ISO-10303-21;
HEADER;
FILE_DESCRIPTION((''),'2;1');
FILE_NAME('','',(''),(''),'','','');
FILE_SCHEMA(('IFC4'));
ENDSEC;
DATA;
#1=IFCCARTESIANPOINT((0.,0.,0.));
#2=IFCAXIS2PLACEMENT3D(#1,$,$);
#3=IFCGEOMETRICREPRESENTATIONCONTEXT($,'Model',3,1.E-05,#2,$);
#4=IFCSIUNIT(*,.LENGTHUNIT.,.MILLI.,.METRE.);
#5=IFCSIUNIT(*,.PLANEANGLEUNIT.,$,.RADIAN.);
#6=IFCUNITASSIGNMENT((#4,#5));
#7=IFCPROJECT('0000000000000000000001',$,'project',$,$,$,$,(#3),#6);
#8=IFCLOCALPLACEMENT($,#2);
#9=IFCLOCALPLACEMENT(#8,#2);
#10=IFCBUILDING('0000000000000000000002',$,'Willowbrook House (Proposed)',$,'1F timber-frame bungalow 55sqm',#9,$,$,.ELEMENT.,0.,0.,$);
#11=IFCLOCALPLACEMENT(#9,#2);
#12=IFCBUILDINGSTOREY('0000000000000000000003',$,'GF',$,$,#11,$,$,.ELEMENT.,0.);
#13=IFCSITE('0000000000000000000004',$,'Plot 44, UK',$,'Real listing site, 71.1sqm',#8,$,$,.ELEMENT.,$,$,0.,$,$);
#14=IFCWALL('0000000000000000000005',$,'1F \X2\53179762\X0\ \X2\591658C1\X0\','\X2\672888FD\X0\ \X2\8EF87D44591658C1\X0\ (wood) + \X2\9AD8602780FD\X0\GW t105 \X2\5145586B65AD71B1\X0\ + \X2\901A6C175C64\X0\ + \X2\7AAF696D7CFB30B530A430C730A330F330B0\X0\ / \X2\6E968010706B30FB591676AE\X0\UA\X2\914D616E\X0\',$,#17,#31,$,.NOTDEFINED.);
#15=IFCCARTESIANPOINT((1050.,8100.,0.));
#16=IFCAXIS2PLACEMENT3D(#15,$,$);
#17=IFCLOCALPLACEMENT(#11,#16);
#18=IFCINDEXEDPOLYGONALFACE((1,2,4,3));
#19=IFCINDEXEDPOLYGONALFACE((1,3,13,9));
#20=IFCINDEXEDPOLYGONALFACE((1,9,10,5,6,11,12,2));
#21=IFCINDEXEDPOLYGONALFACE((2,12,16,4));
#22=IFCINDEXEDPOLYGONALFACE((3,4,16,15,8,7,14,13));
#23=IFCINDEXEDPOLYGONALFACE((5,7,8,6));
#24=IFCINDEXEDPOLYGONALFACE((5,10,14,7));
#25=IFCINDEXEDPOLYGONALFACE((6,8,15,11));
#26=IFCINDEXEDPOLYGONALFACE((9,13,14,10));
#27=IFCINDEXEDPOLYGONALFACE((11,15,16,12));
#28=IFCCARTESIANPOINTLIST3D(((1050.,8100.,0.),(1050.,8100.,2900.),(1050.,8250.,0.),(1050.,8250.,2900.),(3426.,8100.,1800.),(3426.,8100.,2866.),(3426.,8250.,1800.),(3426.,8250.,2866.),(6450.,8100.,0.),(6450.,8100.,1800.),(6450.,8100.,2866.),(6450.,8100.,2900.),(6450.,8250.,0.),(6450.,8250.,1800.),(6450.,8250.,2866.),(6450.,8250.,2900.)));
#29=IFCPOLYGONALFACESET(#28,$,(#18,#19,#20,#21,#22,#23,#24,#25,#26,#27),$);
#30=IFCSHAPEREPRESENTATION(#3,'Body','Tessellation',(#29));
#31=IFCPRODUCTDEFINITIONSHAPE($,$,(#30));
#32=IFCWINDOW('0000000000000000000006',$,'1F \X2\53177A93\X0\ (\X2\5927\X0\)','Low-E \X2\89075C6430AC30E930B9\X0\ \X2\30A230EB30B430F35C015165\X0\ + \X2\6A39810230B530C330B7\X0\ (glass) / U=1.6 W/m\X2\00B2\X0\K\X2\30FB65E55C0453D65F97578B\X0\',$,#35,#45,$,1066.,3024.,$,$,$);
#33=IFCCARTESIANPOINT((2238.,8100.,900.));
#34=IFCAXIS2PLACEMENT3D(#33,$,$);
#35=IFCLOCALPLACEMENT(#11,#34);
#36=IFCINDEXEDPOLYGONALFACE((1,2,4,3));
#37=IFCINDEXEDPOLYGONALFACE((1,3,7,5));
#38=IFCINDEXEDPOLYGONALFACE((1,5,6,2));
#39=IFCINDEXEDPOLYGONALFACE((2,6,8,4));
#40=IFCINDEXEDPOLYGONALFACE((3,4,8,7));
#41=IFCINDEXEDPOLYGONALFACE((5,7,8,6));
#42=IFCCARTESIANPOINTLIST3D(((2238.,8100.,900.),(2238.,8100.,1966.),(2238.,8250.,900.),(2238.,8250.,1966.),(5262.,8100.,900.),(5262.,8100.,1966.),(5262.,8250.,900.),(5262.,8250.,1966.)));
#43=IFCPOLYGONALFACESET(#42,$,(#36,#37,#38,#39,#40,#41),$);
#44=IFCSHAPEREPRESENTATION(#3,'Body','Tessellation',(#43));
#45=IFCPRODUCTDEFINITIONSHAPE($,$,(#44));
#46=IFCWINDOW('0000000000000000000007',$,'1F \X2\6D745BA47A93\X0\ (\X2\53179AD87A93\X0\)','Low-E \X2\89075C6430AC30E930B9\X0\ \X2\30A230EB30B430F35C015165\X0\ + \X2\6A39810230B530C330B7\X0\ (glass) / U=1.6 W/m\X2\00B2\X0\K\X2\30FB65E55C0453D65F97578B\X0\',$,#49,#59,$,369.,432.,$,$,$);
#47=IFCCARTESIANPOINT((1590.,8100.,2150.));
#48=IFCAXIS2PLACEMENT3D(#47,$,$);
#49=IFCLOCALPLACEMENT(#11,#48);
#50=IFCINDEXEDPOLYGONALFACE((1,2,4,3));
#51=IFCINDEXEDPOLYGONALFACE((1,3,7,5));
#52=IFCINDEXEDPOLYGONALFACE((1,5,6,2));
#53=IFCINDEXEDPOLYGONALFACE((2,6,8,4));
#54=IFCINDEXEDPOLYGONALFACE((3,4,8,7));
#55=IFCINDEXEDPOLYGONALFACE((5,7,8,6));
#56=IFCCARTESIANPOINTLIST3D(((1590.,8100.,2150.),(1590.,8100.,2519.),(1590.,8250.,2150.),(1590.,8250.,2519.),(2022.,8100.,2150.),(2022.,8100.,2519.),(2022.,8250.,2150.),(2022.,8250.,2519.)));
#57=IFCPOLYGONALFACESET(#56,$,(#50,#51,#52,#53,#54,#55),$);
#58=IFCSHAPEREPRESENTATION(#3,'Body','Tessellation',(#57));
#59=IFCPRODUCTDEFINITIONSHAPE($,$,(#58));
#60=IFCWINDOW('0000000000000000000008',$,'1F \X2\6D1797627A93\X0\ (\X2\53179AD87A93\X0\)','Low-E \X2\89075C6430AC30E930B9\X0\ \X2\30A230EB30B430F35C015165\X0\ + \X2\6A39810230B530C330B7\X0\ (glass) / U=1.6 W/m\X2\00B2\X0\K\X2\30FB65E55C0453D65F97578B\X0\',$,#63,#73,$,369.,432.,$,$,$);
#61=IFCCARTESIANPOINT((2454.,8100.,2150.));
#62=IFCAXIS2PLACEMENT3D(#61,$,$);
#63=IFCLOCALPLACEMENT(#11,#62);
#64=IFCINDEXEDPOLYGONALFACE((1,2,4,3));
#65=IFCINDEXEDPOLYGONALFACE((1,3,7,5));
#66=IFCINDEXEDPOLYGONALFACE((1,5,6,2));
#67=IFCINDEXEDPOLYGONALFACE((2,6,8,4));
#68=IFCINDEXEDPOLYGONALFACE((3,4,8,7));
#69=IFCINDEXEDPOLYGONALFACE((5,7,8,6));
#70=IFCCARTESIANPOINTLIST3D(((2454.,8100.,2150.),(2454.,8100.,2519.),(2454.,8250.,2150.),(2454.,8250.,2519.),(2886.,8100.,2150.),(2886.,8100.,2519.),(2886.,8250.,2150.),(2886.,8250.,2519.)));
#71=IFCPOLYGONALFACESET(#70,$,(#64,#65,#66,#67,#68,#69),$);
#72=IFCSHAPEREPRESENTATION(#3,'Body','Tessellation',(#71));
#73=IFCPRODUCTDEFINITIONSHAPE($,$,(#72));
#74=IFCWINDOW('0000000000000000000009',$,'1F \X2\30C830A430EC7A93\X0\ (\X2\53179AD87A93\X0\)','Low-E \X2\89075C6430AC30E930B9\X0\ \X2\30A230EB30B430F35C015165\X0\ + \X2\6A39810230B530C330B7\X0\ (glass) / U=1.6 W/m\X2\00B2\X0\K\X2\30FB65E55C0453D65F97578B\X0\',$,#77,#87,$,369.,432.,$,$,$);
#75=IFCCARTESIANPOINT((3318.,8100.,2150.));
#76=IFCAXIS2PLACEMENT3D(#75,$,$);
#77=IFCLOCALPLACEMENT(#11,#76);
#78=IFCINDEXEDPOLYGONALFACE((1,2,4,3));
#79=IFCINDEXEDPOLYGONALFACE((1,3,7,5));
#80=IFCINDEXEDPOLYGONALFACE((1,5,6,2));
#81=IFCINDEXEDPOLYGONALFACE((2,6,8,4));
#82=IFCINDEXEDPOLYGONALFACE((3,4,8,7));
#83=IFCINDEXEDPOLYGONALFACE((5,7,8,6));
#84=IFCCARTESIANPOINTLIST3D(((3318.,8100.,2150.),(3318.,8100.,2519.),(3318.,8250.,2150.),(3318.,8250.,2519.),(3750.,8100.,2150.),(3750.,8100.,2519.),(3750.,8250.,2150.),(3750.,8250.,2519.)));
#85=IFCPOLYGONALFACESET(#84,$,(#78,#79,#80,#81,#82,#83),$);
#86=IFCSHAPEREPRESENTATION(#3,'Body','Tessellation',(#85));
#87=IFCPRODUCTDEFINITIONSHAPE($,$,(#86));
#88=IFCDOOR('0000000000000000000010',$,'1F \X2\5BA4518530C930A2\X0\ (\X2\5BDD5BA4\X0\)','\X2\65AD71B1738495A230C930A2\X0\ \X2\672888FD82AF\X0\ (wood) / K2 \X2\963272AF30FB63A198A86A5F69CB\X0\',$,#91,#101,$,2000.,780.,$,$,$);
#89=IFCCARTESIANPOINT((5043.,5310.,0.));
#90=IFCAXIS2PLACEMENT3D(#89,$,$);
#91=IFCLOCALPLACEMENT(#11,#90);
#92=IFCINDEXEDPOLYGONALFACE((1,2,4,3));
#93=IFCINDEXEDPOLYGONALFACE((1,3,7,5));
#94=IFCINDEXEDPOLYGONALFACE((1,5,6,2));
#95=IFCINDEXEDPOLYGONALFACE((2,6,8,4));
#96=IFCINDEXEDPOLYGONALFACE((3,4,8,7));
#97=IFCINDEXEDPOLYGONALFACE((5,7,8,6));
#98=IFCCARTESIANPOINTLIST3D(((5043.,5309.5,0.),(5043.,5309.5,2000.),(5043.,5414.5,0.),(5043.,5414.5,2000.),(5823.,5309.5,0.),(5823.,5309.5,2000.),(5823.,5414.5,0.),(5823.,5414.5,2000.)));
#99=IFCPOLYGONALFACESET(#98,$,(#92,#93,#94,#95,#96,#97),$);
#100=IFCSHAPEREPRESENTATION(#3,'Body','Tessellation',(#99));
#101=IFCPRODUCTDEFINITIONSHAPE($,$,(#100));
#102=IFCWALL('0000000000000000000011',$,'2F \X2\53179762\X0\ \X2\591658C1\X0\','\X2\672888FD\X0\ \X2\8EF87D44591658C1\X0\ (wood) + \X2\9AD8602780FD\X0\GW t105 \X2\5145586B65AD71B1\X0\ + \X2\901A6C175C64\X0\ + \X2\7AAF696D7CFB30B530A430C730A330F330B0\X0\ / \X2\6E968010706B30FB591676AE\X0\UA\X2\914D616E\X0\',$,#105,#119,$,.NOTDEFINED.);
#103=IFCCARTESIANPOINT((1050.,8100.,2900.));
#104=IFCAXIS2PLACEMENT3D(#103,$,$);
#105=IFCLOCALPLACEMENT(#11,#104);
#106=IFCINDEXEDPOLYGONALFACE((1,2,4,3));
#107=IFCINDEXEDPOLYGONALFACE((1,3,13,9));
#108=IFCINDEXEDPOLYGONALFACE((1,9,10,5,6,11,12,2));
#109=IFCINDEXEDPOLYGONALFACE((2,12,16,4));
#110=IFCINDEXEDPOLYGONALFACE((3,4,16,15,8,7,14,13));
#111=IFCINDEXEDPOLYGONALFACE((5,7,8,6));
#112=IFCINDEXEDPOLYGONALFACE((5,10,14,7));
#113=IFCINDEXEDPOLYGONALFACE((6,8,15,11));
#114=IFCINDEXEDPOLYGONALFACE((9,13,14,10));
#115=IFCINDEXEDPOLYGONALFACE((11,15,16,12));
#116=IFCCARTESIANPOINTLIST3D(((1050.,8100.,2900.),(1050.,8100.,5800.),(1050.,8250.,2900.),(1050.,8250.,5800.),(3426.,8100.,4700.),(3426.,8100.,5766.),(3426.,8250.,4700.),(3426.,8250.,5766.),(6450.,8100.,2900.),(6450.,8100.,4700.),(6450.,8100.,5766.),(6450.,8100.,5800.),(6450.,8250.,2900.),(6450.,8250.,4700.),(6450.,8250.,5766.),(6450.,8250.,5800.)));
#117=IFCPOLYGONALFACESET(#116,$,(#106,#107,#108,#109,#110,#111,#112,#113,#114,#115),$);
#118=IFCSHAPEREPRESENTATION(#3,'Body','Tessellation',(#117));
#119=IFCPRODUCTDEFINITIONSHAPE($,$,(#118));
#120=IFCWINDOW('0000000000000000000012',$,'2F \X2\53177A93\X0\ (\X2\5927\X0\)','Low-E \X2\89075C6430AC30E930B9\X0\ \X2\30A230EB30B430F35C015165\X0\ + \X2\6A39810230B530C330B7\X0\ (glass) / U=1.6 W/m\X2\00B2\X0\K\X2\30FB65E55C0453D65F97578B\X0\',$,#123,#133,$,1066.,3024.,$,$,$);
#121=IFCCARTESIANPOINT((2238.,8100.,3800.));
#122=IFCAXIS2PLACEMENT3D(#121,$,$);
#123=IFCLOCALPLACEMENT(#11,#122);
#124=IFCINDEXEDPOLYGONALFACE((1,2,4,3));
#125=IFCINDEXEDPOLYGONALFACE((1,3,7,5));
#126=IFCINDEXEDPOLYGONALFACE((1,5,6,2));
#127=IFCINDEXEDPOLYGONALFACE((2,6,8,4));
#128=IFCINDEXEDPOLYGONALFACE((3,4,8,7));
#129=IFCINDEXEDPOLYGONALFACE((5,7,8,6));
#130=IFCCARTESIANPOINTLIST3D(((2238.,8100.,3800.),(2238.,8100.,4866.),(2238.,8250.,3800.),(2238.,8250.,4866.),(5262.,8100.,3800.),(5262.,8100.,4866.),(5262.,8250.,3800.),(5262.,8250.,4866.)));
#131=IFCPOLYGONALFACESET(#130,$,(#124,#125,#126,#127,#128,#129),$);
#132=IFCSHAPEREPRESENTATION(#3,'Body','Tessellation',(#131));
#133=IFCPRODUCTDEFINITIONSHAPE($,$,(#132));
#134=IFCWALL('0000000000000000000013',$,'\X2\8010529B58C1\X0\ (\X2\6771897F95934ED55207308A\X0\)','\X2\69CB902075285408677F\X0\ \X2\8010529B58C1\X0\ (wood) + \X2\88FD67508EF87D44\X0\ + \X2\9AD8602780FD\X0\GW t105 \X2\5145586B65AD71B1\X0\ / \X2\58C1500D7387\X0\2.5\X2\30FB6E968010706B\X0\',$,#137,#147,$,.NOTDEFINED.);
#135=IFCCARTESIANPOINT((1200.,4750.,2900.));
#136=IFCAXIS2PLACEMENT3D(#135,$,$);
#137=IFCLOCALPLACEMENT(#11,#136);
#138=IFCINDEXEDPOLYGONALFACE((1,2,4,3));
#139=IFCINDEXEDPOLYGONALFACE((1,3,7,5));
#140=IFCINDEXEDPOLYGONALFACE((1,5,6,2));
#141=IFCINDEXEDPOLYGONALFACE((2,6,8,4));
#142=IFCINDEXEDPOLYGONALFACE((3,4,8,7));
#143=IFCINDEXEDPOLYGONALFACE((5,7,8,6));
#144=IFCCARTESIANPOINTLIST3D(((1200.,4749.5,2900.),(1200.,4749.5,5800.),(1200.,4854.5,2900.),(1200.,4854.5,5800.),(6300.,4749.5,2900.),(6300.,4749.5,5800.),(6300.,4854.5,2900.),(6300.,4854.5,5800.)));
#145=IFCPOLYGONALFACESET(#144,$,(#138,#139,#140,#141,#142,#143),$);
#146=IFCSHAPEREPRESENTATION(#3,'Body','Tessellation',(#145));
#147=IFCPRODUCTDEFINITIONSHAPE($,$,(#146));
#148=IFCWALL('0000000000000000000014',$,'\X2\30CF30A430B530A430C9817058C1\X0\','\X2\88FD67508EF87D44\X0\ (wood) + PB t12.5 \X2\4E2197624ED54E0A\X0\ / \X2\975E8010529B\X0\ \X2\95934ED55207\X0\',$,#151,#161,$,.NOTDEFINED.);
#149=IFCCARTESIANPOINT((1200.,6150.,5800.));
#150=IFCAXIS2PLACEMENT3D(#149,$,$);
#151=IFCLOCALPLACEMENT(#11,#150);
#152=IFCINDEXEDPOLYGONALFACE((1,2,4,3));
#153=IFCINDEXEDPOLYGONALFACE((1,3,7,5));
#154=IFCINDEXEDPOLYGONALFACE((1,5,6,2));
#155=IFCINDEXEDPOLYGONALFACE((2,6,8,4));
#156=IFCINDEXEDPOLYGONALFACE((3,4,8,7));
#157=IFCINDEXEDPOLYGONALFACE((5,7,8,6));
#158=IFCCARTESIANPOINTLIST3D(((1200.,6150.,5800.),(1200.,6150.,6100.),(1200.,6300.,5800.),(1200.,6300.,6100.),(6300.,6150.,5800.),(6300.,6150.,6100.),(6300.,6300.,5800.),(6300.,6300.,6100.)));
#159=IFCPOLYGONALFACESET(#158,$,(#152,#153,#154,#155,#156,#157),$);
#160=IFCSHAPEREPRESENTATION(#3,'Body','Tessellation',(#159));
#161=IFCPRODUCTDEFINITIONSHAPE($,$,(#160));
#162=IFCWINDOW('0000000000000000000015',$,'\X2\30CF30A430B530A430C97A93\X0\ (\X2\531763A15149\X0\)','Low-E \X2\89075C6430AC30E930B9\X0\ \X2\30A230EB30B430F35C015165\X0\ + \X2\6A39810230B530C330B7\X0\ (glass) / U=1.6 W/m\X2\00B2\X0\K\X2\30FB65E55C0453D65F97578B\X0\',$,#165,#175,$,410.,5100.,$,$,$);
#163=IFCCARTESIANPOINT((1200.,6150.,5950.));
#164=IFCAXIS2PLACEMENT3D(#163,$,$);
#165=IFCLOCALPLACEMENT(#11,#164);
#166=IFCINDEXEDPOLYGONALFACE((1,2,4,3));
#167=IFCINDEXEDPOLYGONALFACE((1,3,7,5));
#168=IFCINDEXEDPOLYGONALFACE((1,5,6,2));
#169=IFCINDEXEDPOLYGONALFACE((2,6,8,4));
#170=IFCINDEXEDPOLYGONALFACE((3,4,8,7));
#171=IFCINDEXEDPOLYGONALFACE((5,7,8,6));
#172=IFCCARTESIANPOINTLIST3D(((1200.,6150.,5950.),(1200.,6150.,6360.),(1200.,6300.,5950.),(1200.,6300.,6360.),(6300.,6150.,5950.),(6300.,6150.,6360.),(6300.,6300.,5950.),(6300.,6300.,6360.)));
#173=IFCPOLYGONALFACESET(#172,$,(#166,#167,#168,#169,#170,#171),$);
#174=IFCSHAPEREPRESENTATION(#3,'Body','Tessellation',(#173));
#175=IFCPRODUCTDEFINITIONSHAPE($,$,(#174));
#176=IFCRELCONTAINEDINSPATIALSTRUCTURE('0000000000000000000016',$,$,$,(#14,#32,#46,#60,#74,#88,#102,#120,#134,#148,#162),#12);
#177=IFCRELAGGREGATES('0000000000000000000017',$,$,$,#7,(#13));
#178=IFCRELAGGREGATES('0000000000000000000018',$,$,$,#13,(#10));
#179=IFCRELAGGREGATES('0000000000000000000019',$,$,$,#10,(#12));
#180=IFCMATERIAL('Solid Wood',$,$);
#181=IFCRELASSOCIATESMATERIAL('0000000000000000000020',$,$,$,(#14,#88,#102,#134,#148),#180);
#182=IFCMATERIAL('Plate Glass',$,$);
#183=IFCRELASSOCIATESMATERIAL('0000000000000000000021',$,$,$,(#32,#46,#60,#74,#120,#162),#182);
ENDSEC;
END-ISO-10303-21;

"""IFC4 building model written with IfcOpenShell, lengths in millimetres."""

from ifc_helpers import new_model, si_unit, frame, frame_2d, origin, place, context, project, spatial, rectangle, extrude, material, element, fill, save


model = new_model("IFC4")

# Units and contexts
model_context = context("Model", 3, precision=1e-05, world=origin())
ifc_project = project(units=[si_unit("LENGTHUNIT", "METRE", prefix="MILLI"), si_unit("PLANEANGLEUNIT", "RADIAN")], contexts=[model_context])

# Site, building, storey
site_placement = place(None, origin())
site = spatial("IfcSite", under=ifc_project, at=site_placement, Name="Plot 44, UK", ObjectType="Real listing site, 71.1sqm", CompositionType="ELEMENT", RefElevation=0.0)
building_placement = place(site_placement, origin())
building = spatial("IfcBuilding", under=site, at=building_placement, Name="Willowbrook House (Proposed)", ObjectType="1F timber-frame bungalow 55sqm", CompositionType="ELEMENT", ElevationOfRefHeight=0.0, ElevationOfTerrain=0.0)
storey_placement = place(building_placement, origin())
storey = spatial("IfcBuildingStorey", under=building, at=storey_placement, Name="GF", CompositionType="ELEMENT", Elevation=0.0)

# Wall, openings, windows
ifc_material_1 = material(Name="Solid Wood")
wall_1_placement = place(storey_placement, frame((1050.0, 8100.0, 0.0)))
wall_1 = element("IfcWall", 1, at=wall_1_placement, inside=storey, material=ifc_material_1, Name="1F 北面 外壁", Description="木製 軸組外壁 (wood) + 高性能GW t105 充填断熱 + 通気層 + 窯業系サイディング / 準耐火・外皮UA配慮", PredefinedType="NOTDEFINED", context=model_context, shape_type="SweptSolid", body=[
    extrude(rectangle(XDim=5400.0, YDim=150.0, at=frame_2d((2700.0, 75.0))), frame((1050.0, 8100.0, 0.0)), (0.0, 0.0, 1.0), 2900.0),
])
opening_1_placement = place(storey_placement, frame((2238.0, 8100.0, 900.0)))
opening_1 = element("IfcOpeningElement", 2, at=opening_1_placement, cuts=wall_1, PredefinedType="NOTDEFINED", context=model_context, shape_type="SweptSolid", body=[
    extrude(rectangle(XDim=3024.0, YDim=150.0, at=frame_2d((1512.0, 75.0))), frame((2238.0, 8100.0, 900.0)), (0.0, 0.0, 1.0), 1066.0),
])
opening_2_placement = place(storey_placement, frame((1590.0, 8100.0, 2150.0)))
opening_2 = element("IfcOpeningElement", 3, at=opening_2_placement, cuts=wall_1, PredefinedType="NOTDEFINED", context=model_context, shape_type="SweptSolid", body=[
    extrude(rectangle(XDim=432.0, YDim=150.0, at=frame_2d((216.0, 75.0))), frame((1590.0, 8100.0, 2150.0)), (0.0, 0.0, 1.0), 369.0),
])
opening_3_placement = place(storey_placement, frame((2454.0, 8100.0, 2150.0)))
opening_3 = element("IfcOpeningElement", 4, at=opening_3_placement, cuts=wall_1, PredefinedType="NOTDEFINED", context=model_context, shape_type="SweptSolid", body=[
    extrude(rectangle(XDim=432.0, YDim=150.0, at=frame_2d((216.0, 75.0))), frame((2454.0, 8100.0, 2150.0)), (0.0, 0.0, 1.0), 369.0),
])
opening_4_placement = place(storey_placement, frame((3318.0, 8100.0, 2150.0)))
opening_4 = element("IfcOpeningElement", 5, at=opening_4_placement, cuts=wall_1, PredefinedType="NOTDEFINED", context=model_context, shape_type="SweptSolid", body=[
    extrude(rectangle(XDim=432.0, YDim=150.0, at=frame_2d((216.0, 75.0))), frame((3318.0, 8100.0, 2150.0)), (0.0, 0.0, 1.0), 369.0),
])
ifc_material_2 = material(Name="Plate Glass")
window_1_placement = place(storey_placement, frame((2238.0, 8100.0, 900.0)))
window_1 = element("IfcWindow", 6, at=window_1_placement, inside=storey, material=ifc_material_2, Name="1F 北窓 (大)", Description="Low-E 複層ガラス アルゴン封入 + 樹脂サッシ (glass) / U=1.6 W/m²K・日射取得型", OverallHeight=1066.0, OverallWidth=3024.0, context=model_context, shape_type="SweptSolid", body=[
    extrude(rectangle(XDim=3024.0, YDim=150.0, at=frame_2d((1512.0, 75.0))), frame((2238.0, 8100.0, 900.0)), (0.0, 0.0, 1.0), 1066.0),
])
fill(opening_1, window_1)
window_2_placement = place(storey_placement, frame((1590.0, 8100.0, 2150.0)))
window_2 = element("IfcWindow", 7, at=window_2_placement, inside=storey, material=ifc_material_2, Name="1F 浴室窓 (北高窓)", Description="Low-E 複層ガラス アルゴン封入 + 樹脂サッシ (glass) / U=1.6 W/m²K・日射取得型", OverallHeight=369.0, OverallWidth=432.0, context=model_context, shape_type="SweptSolid", body=[
    extrude(rectangle(XDim=432.0, YDim=150.0, at=frame_2d((216.0, 75.0))), frame((1590.0, 8100.0, 2150.0)), (0.0, 0.0, 1.0), 369.0),
])
fill(opening_2, window_2)
window_3_placement = place(storey_placement, frame((2454.0, 8100.0, 2150.0)))
window_3 = element("IfcWindow", 8, at=window_3_placement, inside=storey, material=ifc_material_2, Name="1F 洗面窓 (北高窓)", Description="Low-E 複層ガラス アルゴン封入 + 樹脂サッシ (glass) / U=1.6 W/m²K・日射取得型", OverallHeight=369.0, OverallWidth=432.0, context=model_context, shape_type="SweptSolid", body=[
    extrude(rectangle(XDim=432.0, YDim=150.0, at=frame_2d((216.0, 75.0))), frame((2454.0, 8100.0, 2150.0)), (0.0, 0.0, 1.0), 369.0),
])
fill(opening_3, window_3)
window_4_placement = place(storey_placement, frame((3318.0, 8100.0, 2150.0)))
window_4 = element("IfcWindow", 9, at=window_4_placement, inside=storey, material=ifc_material_2, Name="1F トイレ窓 (北高窓)", Description="Low-E 複層ガラス アルゴン封入 + 樹脂サッシ (glass) / U=1.6 W/m²K・日射取得型", OverallHeight=369.0, OverallWidth=432.0, context=model_context, shape_type="SweptSolid", body=[
    extrude(rectangle(XDim=432.0, YDim=150.0, at=frame_2d((216.0, 75.0))), frame((3318.0, 8100.0, 2150.0)), (0.0, 0.0, 1.0), 369.0),
])
fill(opening_4, window_4)

# Door
door_1_placement = place(storey_placement, frame((5043.0, 5310.0, 0.0)))
element("IfcDoor", 10, at=door_1_placement, inside=storey, material=ifc_material_1, Name="1F 室内ドア (寝室)", Description="断熱玄関ドア 木製芯 (wood) / K2 防犯・採風機構", OverallHeight=2000.0, OverallWidth=780.0, context=model_context, shape_type="SweptSolid", body=[
    extrude(rectangle(XDim=780.0, YDim=105.0, at=frame_2d((390.0, 52.0))), frame((5043.0, 5310.0, 0.0)), (0.0, 0.0, 1.0), 2000.0),
])

# Wall, opening, window
wall_2_placement = place(storey_placement, frame((1050.0, 8100.0, 2900.0)))
wall_2 = element("IfcWall", 11, at=wall_2_placement, inside=storey, material=ifc_material_1, Name="2F 北面 外壁", Description="木製 軸組外壁 (wood) + 高性能GW t105 充填断熱 + 通気層 + 窯業系サイディング / 準耐火・外皮UA配慮", PredefinedType="NOTDEFINED", context=model_context, shape_type="SweptSolid", body=[
    extrude(rectangle(XDim=5400.0, YDim=150.0, at=frame_2d((2700.0, 75.0))), frame((1050.0, 8100.0, 2900.0)), (0.0, 0.0, 1.0), 2900.0),
])
opening_5_placement = place(storey_placement, frame((2238.0, 8100.0, 3800.0)))
opening_5 = element("IfcOpeningElement", 12, at=opening_5_placement, cuts=wall_2, PredefinedType="NOTDEFINED", context=model_context, shape_type="SweptSolid", body=[
    extrude(rectangle(XDim=3024.0, YDim=150.0, at=frame_2d((1512.0, 75.0))), frame((2238.0, 8100.0, 3800.0)), (0.0, 0.0, 1.0), 1066.0),
])
window_5_placement = place(storey_placement, frame((2238.0, 8100.0, 3800.0)))
window_5 = element("IfcWindow", 13, at=window_5_placement, inside=storey, material=ifc_material_2, Name="2F 北窓 (大)", Description="Low-E 複層ガラス アルゴン封入 + 樹脂サッシ (glass) / U=1.6 W/m²K・日射取得型", OverallHeight=1066.0, OverallWidth=3024.0, context=model_context, shape_type="SweptSolid", body=[
    extrude(rectangle(XDim=3024.0, YDim=150.0, at=frame_2d((1512.0, 75.0))), frame((2238.0, 8100.0, 3800.0)), (0.0, 0.0, 1.0), 1066.0),
])
fill(opening_5, window_5)

# Wall
wall_3_placement = place(storey_placement, frame((1200.0, 4750.0, 2900.0)))
element("IfcWall", 14, at=wall_3_placement, inside=storey, material=ifc_material_1, Name="耐力壁 (東西間仕切り)", Description="構造用合板 耐力壁 (wood) + 製材軸組 + 高性能GW t105 充填断熱 / 壁倍率2.5・準耐火", PredefinedType="NOTDEFINED", context=model_context, shape_type="SweptSolid", body=[
    extrude(rectangle(XDim=5100.0, YDim=105.0, at=frame_2d((2550.0, 52.0))), frame((1200.0, 4750.0, 2900.0)), (0.0, 0.0, 1.0), 2900.0),
])

# Wall, opening, window
wall_4_placement = place(storey_placement, frame((1200.0, 6150.0, 5800.0)))
wall_4 = element("IfcWall", 15, at=wall_4_placement, inside=storey, material=ifc_material_1, Name="ハイサイド腰壁", Description="製材軸組 (wood) + PB t12.5 両面仕上 / 非耐力 間仕切", PredefinedType="NOTDEFINED", context=model_context, shape_type="SweptSolid", body=[
    extrude(rectangle(XDim=5100.0, YDim=150.0, at=frame_2d((2550.0, 75.0))), frame((1200.0, 6150.0, 5800.0)), (0.0, 0.0, 1.0), 700.0),
])
opening_6_placement = place(storey_placement, frame((1200.0, 6150.0, 5950.0)))
opening_6 = element("IfcOpeningElement", 16, at=opening_6_placement, cuts=wall_4, PredefinedType="NOTDEFINED", context=model_context, shape_type="SweptSolid", body=[
    extrude(rectangle(XDim=5100.0, YDim=150.0, at=frame_2d((2550.0, 75.0))), frame((1200.0, 6150.0, 5950.0)), (0.0, 0.0, 1.0), 410.0),
])
window_6_placement = place(storey_placement, frame((1200.0, 6150.0, 5950.0)))
window_6 = element("IfcWindow", 17, at=window_6_placement, inside=storey, material=ifc_material_2, Name="ハイサイド窓 (北採光)", Description="Low-E 複層ガラス アルゴン封入 + 樹脂サッシ (glass) / U=1.6 W/m²K・日射取得型", OverallHeight=410.0, OverallWidth=5100.0, context=model_context, shape_type="SweptSolid", body=[
    extrude(rectangle(XDim=5100.0, YDim=150.0, at=frame_2d((2550.0, 75.0))), frame((1200.0, 6150.0, 5950.0)), (0.0, 0.0, 1.0), 410.0),
])
fill(opening_6, window_6)

save(model, "model.ifc")
